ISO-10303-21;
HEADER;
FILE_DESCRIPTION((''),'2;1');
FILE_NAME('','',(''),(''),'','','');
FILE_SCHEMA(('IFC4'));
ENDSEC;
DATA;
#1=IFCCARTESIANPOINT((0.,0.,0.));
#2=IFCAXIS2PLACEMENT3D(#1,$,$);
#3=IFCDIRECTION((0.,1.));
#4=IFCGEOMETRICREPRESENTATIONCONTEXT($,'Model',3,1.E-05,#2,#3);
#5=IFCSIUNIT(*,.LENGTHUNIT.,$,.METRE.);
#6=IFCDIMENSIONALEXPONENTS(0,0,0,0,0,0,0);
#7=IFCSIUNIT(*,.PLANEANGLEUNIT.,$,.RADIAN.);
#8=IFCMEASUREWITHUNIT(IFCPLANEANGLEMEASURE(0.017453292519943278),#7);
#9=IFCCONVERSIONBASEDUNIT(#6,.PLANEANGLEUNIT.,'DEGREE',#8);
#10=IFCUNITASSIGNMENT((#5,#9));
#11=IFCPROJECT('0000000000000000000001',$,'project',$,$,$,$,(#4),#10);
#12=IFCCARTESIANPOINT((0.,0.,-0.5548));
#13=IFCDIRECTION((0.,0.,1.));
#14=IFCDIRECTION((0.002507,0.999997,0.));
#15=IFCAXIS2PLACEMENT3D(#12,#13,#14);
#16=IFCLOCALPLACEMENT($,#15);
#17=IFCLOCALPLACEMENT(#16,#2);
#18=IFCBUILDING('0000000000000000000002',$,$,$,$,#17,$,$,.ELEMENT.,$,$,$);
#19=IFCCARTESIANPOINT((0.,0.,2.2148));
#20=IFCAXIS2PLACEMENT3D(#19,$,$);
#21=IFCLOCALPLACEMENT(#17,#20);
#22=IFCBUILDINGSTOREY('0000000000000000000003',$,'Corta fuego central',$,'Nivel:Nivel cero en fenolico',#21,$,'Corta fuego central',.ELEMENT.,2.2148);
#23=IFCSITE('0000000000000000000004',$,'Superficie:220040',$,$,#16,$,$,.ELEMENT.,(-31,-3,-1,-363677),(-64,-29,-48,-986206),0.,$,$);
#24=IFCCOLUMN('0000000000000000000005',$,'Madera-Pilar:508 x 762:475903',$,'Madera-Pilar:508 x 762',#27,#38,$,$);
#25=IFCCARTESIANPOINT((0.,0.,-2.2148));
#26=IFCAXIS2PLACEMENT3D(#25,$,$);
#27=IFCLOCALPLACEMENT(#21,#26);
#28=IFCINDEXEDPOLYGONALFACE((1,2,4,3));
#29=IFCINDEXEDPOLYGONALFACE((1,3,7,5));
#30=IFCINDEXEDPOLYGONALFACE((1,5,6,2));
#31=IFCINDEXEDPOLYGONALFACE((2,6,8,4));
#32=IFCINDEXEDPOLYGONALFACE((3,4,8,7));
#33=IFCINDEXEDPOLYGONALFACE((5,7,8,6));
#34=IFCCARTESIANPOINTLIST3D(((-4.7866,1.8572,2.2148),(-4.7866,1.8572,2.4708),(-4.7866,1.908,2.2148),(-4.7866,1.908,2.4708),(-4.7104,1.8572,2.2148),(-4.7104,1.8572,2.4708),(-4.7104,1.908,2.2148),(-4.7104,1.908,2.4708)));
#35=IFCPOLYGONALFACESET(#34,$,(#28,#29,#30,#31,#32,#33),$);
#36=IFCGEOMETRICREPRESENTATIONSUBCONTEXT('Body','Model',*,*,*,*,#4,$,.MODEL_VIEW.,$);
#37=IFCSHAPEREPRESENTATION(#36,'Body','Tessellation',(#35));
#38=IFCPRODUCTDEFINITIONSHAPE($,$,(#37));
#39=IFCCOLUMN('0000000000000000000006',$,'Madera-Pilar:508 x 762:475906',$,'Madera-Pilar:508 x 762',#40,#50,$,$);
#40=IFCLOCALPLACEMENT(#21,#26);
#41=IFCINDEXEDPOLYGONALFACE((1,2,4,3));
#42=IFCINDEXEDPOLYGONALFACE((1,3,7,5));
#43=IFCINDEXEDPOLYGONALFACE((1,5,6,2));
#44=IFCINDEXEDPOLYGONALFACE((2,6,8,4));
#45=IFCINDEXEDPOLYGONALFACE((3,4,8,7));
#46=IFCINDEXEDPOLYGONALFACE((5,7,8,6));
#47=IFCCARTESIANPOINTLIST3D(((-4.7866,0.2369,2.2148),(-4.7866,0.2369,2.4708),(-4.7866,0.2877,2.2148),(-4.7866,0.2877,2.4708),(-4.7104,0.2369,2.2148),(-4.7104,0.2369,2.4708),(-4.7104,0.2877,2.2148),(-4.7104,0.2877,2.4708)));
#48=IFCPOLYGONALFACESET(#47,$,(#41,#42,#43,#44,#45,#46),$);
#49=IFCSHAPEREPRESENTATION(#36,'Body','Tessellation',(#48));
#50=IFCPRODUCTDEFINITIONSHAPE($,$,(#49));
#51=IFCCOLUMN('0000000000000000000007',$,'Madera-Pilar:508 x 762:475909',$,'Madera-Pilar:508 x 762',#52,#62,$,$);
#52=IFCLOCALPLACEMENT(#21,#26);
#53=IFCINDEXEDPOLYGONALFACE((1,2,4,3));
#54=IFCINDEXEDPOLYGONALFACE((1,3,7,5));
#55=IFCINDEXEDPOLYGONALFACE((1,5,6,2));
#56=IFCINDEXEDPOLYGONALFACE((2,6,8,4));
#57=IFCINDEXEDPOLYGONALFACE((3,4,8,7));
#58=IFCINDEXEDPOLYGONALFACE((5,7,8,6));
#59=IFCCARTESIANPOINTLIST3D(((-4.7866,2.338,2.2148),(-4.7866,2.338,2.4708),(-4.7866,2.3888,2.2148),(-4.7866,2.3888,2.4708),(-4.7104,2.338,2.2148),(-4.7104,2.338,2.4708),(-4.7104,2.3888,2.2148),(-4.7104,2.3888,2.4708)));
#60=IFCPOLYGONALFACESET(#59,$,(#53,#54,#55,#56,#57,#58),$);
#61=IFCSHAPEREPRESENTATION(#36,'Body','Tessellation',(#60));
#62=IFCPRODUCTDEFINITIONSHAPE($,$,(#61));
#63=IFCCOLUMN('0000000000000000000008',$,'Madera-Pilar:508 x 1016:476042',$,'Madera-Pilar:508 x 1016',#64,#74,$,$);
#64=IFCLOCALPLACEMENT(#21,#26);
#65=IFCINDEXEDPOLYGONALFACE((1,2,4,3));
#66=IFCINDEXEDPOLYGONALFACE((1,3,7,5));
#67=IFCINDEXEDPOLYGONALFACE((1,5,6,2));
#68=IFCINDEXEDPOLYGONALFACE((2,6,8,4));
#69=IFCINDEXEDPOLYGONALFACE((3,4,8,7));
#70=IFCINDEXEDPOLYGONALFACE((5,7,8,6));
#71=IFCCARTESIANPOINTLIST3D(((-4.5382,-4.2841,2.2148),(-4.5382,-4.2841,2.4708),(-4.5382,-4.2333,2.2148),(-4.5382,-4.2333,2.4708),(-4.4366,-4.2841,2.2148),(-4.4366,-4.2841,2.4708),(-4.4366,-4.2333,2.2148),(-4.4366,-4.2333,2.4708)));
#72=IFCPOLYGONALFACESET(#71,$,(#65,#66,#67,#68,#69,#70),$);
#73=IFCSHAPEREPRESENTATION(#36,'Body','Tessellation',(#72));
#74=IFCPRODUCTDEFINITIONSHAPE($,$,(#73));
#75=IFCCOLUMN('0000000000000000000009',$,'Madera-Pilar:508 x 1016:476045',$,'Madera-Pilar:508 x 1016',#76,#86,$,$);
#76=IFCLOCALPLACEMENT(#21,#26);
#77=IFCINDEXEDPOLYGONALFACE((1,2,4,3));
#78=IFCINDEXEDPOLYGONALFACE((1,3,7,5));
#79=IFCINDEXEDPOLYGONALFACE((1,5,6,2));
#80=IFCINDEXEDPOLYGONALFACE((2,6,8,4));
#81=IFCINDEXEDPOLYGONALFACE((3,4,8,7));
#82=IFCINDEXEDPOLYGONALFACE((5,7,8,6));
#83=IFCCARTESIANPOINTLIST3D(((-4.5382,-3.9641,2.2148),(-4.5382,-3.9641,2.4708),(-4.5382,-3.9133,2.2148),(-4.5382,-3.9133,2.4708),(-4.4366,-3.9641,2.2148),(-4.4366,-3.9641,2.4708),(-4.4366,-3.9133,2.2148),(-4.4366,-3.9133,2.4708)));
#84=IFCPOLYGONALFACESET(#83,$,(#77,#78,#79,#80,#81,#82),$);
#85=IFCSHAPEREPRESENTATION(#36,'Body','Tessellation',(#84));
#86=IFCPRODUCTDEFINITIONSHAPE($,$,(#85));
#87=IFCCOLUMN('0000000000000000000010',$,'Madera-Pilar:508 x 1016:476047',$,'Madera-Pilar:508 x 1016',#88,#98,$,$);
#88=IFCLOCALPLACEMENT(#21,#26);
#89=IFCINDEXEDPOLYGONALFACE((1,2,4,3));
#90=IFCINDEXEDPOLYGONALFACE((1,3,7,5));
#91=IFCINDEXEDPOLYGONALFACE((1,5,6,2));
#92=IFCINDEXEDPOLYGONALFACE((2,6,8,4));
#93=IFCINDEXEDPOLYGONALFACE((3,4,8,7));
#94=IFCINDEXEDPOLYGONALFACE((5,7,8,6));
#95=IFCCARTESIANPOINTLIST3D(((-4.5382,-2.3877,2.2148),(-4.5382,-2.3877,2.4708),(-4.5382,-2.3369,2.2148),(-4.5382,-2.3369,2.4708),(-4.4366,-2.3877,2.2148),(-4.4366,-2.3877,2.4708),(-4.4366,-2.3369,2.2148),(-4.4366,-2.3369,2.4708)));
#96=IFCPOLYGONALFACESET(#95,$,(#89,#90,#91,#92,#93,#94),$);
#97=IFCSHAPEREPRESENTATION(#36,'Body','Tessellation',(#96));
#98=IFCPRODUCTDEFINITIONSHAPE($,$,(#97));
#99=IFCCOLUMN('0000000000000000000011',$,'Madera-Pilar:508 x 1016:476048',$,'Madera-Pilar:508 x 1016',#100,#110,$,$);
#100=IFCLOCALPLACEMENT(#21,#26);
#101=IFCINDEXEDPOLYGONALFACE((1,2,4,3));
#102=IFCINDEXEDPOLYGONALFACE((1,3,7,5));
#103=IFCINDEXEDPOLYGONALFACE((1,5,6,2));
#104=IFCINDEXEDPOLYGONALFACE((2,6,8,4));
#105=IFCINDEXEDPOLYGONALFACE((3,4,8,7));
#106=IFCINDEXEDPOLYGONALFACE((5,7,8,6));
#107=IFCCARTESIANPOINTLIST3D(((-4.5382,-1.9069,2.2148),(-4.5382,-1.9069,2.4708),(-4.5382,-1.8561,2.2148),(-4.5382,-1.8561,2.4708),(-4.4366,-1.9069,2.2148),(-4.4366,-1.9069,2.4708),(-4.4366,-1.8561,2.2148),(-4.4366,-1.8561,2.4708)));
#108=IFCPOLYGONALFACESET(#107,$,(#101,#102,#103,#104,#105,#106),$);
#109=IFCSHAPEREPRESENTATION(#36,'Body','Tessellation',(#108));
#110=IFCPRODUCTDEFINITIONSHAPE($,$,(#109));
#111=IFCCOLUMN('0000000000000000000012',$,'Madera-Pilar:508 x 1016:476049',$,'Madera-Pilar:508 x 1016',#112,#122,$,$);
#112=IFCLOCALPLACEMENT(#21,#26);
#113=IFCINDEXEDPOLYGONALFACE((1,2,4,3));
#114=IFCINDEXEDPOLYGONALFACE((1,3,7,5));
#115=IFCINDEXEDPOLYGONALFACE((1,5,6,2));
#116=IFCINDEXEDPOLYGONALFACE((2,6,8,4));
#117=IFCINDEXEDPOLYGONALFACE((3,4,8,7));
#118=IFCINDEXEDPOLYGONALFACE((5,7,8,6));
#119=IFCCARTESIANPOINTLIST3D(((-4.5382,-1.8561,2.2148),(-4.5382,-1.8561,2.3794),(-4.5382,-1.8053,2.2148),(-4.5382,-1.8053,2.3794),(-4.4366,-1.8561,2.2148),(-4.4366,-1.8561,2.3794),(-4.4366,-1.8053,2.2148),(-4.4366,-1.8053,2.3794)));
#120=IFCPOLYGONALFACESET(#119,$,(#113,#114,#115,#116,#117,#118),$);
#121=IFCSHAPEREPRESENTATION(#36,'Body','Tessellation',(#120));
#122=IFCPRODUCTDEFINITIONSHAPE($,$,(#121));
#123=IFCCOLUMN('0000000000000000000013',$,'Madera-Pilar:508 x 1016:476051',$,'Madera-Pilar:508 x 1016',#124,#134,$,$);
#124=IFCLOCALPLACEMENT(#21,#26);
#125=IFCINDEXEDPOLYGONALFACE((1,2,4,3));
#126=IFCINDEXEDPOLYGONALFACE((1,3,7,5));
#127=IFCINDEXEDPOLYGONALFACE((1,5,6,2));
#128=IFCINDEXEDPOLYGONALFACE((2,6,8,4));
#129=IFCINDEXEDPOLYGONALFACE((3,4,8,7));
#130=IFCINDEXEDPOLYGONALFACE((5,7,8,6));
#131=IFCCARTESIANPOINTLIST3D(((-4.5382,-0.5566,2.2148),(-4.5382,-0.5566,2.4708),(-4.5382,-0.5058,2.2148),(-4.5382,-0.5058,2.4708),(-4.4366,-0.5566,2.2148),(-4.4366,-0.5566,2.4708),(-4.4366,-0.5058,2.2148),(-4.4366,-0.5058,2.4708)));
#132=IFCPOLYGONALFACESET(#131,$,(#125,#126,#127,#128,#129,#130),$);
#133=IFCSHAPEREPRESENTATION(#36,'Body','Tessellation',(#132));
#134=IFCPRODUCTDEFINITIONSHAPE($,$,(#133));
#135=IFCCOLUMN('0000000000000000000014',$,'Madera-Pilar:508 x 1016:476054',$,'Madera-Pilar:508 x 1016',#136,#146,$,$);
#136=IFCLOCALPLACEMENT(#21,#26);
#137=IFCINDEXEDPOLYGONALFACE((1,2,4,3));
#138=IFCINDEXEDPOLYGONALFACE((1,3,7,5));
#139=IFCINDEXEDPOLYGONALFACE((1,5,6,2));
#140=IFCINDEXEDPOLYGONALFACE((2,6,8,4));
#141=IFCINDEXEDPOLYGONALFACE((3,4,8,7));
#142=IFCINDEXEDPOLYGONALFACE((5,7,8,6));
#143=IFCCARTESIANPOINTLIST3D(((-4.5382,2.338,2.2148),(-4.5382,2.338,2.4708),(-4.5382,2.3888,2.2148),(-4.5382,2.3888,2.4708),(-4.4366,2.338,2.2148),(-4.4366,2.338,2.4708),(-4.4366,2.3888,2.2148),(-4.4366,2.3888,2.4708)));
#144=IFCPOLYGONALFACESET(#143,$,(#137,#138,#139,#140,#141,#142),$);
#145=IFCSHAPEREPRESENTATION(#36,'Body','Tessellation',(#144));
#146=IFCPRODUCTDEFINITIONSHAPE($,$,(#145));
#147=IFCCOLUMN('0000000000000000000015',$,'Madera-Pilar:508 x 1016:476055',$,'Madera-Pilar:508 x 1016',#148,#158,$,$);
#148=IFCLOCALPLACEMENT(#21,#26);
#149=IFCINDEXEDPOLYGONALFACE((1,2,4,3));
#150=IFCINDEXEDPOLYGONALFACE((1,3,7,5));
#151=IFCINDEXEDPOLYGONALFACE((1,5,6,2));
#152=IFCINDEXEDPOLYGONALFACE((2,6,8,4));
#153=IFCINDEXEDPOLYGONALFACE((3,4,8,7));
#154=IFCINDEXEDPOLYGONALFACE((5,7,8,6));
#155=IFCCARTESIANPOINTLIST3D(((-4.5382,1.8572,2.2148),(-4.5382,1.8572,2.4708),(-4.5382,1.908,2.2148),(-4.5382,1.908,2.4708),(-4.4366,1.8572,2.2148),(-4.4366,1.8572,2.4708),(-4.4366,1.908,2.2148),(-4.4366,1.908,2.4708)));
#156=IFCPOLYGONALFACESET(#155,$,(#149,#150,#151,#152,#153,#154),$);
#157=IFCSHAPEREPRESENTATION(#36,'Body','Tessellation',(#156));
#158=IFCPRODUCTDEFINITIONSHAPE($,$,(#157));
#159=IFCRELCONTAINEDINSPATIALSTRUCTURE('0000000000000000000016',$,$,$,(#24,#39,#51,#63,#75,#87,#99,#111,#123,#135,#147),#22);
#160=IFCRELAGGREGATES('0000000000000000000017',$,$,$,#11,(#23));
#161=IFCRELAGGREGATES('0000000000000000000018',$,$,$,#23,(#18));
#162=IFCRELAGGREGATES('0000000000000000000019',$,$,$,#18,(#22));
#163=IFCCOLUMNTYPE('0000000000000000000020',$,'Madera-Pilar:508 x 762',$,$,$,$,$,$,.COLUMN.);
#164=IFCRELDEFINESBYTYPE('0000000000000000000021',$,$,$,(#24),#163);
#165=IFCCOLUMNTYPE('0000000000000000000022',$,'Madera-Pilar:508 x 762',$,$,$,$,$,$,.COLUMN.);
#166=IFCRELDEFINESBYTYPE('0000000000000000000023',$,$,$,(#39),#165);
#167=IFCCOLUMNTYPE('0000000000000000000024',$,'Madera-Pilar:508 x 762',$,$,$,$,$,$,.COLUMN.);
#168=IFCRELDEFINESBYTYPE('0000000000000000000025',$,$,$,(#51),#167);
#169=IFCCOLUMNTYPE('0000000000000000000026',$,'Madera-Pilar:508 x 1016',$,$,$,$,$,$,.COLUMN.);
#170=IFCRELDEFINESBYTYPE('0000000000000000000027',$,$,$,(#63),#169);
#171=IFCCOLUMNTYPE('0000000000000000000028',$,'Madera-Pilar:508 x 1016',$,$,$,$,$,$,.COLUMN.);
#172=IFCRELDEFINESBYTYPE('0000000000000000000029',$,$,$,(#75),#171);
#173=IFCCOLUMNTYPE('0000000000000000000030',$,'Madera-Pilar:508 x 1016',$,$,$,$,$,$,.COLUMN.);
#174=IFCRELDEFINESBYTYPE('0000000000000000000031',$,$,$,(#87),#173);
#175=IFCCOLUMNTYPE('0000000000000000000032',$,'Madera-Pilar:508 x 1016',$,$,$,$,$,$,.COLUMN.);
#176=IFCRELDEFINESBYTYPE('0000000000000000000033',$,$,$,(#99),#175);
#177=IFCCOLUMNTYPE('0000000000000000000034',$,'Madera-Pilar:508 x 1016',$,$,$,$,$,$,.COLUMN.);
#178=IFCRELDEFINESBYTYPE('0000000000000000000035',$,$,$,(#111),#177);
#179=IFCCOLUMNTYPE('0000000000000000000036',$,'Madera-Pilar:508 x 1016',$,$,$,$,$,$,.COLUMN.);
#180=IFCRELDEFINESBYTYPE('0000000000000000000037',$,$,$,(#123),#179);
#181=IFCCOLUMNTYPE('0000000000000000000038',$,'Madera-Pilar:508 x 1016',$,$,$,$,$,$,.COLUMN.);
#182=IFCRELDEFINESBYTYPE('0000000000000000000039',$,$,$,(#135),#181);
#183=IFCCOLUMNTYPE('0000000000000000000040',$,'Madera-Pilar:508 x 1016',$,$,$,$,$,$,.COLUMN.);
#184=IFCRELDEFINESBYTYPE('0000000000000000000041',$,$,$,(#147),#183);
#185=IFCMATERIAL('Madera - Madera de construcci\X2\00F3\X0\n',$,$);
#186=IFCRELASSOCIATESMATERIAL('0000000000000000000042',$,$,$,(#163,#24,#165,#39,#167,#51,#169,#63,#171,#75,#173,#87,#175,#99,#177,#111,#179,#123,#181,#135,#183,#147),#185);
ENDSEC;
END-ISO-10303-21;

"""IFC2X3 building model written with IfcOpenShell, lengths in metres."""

from ifc_helpers import new_model, entity, si_unit, converted_unit, direction, frame, frame_2d, origin, origin_2d_with_axis, place, context, subcontext, project, spatial, rectangle, extrude, source, transform, mapped, material, type_object, type_shapes, element, save


model = new_model("IFC2X3")

# Units and contexts
model_context = context("Model", 3, precision=1e-05, world=origin(), true_north=direction((0.0, 1.0)))
body_context = subcontext(model_context, "Body", "Model", "MODEL_VIEW")
ifc_project = project(units=[si_unit("LENGTHUNIT", "METRE"), converted_unit("PLANEANGLEUNIT", "DEGREE", entity("IfcPlaneAngleMeasure", 0.017453292519943278), si_unit("PLANEANGLEUNIT", "RADIAN"), dimensions=[0, 0, 0, 0, 0, 0, 0])], contexts=[model_context])

# Site, building, storey
site_placement = place(None, frame((0.0, 0.0, -0.5548), z_axis=(0.0, 0.0, 1.0), x_axis=(0.002507, 0.999997, 0.0)))
site = spatial("IfcSite", under=ifc_project, at=site_placement, Name="Superficie:220040", CompositionType="ELEMENT", RefLatitude=(-31, -3, -1, -363677), RefLongitude=(-64, -29, -48, -986206), RefElevation=0.0)
building_placement = place(site_placement, origin())
building = spatial("IfcBuilding", under=site, at=building_placement, CompositionType="ELEMENT")
storey_placement = place(building_placement, frame((0.0, 0.0, 2.2148)))
storey = spatial("IfcBuildingStorey", under=building, at=storey_placement, Name="Corta fuego central", ObjectType="Nivel:Nivel cero en fenolico", LongName="Corta fuego central", CompositionType="ELEMENT", Elevation=2.2148)

# Columns
ifc_material = material(Name="Madera - Madera de construcción")
column_type_1 = type_object("IfcColumnType", Name="Madera-Pilar:508 x 762", PredefinedType="COLUMN", material=ifc_material)
shared_shape_1 = source(origin(), body_context, "Body", "SweptSolid", [
    extrude(rectangle(XDim=0.0762, YDim=0.0508, at=origin_2d_with_axis()), frame((-4.7485, 1.8826, 2.2148), z_axis=(0.0, 0.0, 1.0), x_axis=(-1.0, 0.0, 0.0)), (0.0, 0.0, 1.0), 0.256),
])
type_shapes(column_type_1, [shared_shape_1])
column_1_placement = place(storey_placement, frame((0.0, 0.0, -2.2148)))
element("IfcColumn", 1, at=column_1_placement, inside=storey, type_object=column_type_1, material=ifc_material, Name="Madera-Pilar:508 x 762:475903", ObjectType="Madera-Pilar:508 x 762", context=body_context, shape_type="MappedRepresentation", body=[
    mapped(shared_shape_1, transform((0.0, 0.0, 0.0), scale=1.0)),
])
column_type_2 = type_object("IfcColumnType", Name="Madera-Pilar:508 x 762", PredefinedType="COLUMN", material=ifc_material)
shared_shape_2 = source(origin(), body_context, "Body", "SweptSolid", [
    extrude(rectangle(XDim=0.0762, YDim=0.0508, at=frame_2d((0.0, 0.0), x_axis=(1.0, 0.0))), frame((-4.7485, 0.2623, 2.2148), z_axis=(0.0, 0.0, 1.0), x_axis=(-1.0, 0.0, 0.0)), (0.0, 0.0, 1.0), 0.256),
])
type_shapes(column_type_2, [shared_shape_2])
column_2_placement = place(storey_placement, frame((0.0, 0.0, -2.2148)))
element("IfcColumn", 2, at=column_2_placement, inside=storey, type_object=column_type_2, material=ifc_material, Name="Madera-Pilar:508 x 762:475906", ObjectType="Madera-Pilar:508 x 762", context=body_context, shape_type="MappedRepresentation", body=[
    mapped(shared_shape_2, transform((0.0, 0.0, 0.0), scale=1.0)),
])
column_type_3 = type_object("IfcColumnType", Name="Madera-Pilar:508 x 762", PredefinedType="COLUMN", material=ifc_material)
shared_shape_3 = source(origin(), body_context, "Body", "SweptSolid", [
    extrude(rectangle(XDim=0.0762, YDim=0.0508, at=origin_2d_with_axis()), frame((-4.7485, 2.3634, 2.2148), z_axis=(0.0, 0.0, 1.0), x_axis=(-1.0, 0.0, 0.0)), (0.0, 0.0, 1.0), 0.256),
])
type_shapes(column_type_3, [shared_shape_3])
column_3_placement = place(storey_placement, frame((0.0, 0.0, -2.2148)))
element("IfcColumn", 3, at=column_3_placement, inside=storey, type_object=column_type_3, material=ifc_material, Name="Madera-Pilar:508 x 762:475909", ObjectType="Madera-Pilar:508 x 762", context=body_context, shape_type="MappedRepresentation", body=[
    mapped(shared_shape_3, transform((0.0, 0.0, 0.0), scale=1.0)),
])
column_type_4 = type_object("IfcColumnType", Name="Madera-Pilar:508 x 1016", PredefinedType="COLUMN", material=ifc_material)
shared_shape_4 = source(origin(), body_context, "Body", "SweptSolid", [
    extrude(rectangle(XDim=0.1016, YDim=0.0508, at=frame_2d((0.0, 0.0), x_axis=(1.0, 0.0))), frame((-4.4874, -4.2587, 2.2148), z_axis=(0.0, 0.0, 1.0), x_axis=(-1.0, 0.0, 0.0)), (0.0, 0.0, 1.0), 0.256),
])
type_shapes(column_type_4, [shared_shape_4])
column_4_placement = place(storey_placement, frame((0.0, 0.0, -2.2148)))
element("IfcColumn", 4, at=column_4_placement, inside=storey, type_object=column_type_4, material=ifc_material, Name="Madera-Pilar:508 x 1016:476042", ObjectType="Madera-Pilar:508 x 1016", context=body_context, shape_type="MappedRepresentation", body=[
    mapped(shared_shape_4, transform((0.0, 0.0, 0.0), scale=1.0)),
])
column_type_5 = type_object("IfcColumnType", Name="Madera-Pilar:508 x 1016", PredefinedType="COLUMN", material=ifc_material)
shared_shape_5 = source(origin(), body_context, "Body", "SweptSolid", [
    extrude(rectangle(XDim=0.1016, YDim=0.0508, at=frame_2d((0.0, 0.0), x_axis=(1.0, 0.0))), frame((-4.4874, -3.9387, 2.2148), z_axis=(0.0, 0.0, 1.0), x_axis=(-1.0, 0.0, 0.0)), (0.0, 0.0, 1.0), 0.256),
])
type_shapes(column_type_5, [shared_shape_5])
column_5_placement = place(storey_placement, frame((0.0, 0.0, -2.2148)))
element("IfcColumn", 5, at=column_5_placement, inside=storey, type_object=column_type_5, material=ifc_material, Name="Madera-Pilar:508 x 1016:476045", ObjectType="Madera-Pilar:508 x 1016", context=body_context, shape_type="MappedRepresentation", body=[
    mapped(shared_shape_5, transform((0.0, 0.0, 0.0), scale=1.0)),
])
column_type_6 = type_object("IfcColumnType", Name="Madera-Pilar:508 x 1016", PredefinedType="COLUMN", material=ifc_material)
shared_shape_6 = source(origin(), body_context, "Body", "SweptSolid", [
    extrude(rectangle(XDim=0.1016, YDim=0.0508, at=frame_2d((0.0, 0.0), x_axis=(1.0, 0.0))), frame((-4.4874, -2.3623, 2.2148), z_axis=(0.0, 0.0, 1.0), x_axis=(-1.0, 0.0, 0.0)), (0.0, 0.0, 1.0), 0.256),
])
type_shapes(column_type_6, [shared_shape_6])
column_6_placement = place(storey_placement, frame((0.0, 0.0, -2.2148)))
element("IfcColumn", 6, at=column_6_placement, inside=storey, type_object=column_type_6, material=ifc_material, Name="Madera-Pilar:508 x 1016:476047", ObjectType="Madera-Pilar:508 x 1016", context=body_context, shape_type="MappedRepresentation", body=[
    mapped(shared_shape_6, transform((0.0, 0.0, 0.0), scale=1.0)),
])
column_type_7 = type_object("IfcColumnType", Name="Madera-Pilar:508 x 1016", PredefinedType="COLUMN", material=ifc_material)
shared_shape_7 = source(origin(), body_context, "Body", "SweptSolid", [
    extrude(rectangle(XDim=0.1016, YDim=0.0508, at=frame_2d((0.0, 0.0), x_axis=(1.0, 0.0))), frame((-4.4874, -1.8815, 2.2148), z_axis=(0.0, 0.0, 1.0), x_axis=(-1.0, 0.0, 0.0)), (0.0, 0.0, 1.0), 0.256),
])
type_shapes(column_type_7, [shared_shape_7])
column_7_placement = place(storey_placement, frame((0.0, 0.0, -2.2148)))
element("IfcColumn", 7, at=column_7_placement, inside=storey, type_object=column_type_7, material=ifc_material, Name="Madera-Pilar:508 x 1016:476048", ObjectType="Madera-Pilar:508 x 1016", context=body_context, shape_type="MappedRepresentation", body=[
    mapped(shared_shape_7, transform((0.0, 0.0, 0.0), scale=1.0)),
])
column_type_8 = type_object("IfcColumnType", Name="Madera-Pilar:508 x 1016", PredefinedType="COLUMN", material=ifc_material)
shared_shape_8 = source(origin(), body_context, "Body", "SweptSolid", [
    extrude(rectangle(XDim=0.1016, YDim=0.0508, at=frame_2d((0.0, 0.0), x_axis=(1.0, 0.0))), frame((-4.4874, -1.8307, 2.2148), z_axis=(0.0, 0.0, 1.0), x_axis=(-1.0, 0.0, 0.0)), (0.0, 0.0, 1.0), 0.1646),
])
type_shapes(column_type_8, [shared_shape_8])
column_8_placement = place(storey_placement, frame((0.0, 0.0, -2.2148)))
element("IfcColumn", 8, at=column_8_placement, inside=storey, type_object=column_type_8, material=ifc_material, Name="Madera-Pilar:508 x 1016:476049", ObjectType="Madera-Pilar:508 x 1016", context=body_context, shape_type="MappedRepresentation", body=[
    mapped(shared_shape_8, transform((0.0, 0.0, 0.0), scale=1.0)),
])
column_type_9 = type_object("IfcColumnType", Name="Madera-Pilar:508 x 1016", PredefinedType="COLUMN", material=ifc_material)
shared_shape_9 = source(origin(), body_context, "Body", "SweptSolid", [
    extrude(rectangle(XDim=0.1016, YDim=0.0508, at=frame_2d((0.0, 0.0), x_axis=(1.0, 0.0))), frame((-4.4874, -0.5312, 2.2148), z_axis=(0.0, 0.0, 1.0), x_axis=(-1.0, 0.0, 0.0)), (0.0, 0.0, 1.0), 0.256),
])
type_shapes(column_type_9, [shared_shape_9])
column_9_placement = place(storey_placement, frame((0.0, 0.0, -2.2148)))
element("IfcColumn", 9, at=column_9_placement, inside=storey, type_object=column_type_9, material=ifc_material, Name="Madera-Pilar:508 x 1016:476051", ObjectType="Madera-Pilar:508 x 1016", context=body_context, shape_type="MappedRepresentation", body=[
    mapped(shared_shape_9, transform((0.0, 0.0, 0.0), scale=1.0)),
])
column_type_10 = type_object("IfcColumnType", Name="Madera-Pilar:508 x 1016", PredefinedType="COLUMN", material=ifc_material)
shared_shape_10 = source(origin(), body_context, "Body", "SweptSolid", [
    extrude(rectangle(XDim=0.1016, YDim=0.0508, at=frame_2d((0.0, 0.0), x_axis=(1.0, 0.0))), frame((-4.4874, 2.3634, 2.2148), z_axis=(0.0, 0.0, 1.0), x_axis=(-1.0, 0.0, 0.0)), (0.0, 0.0, 1.0), 0.256),
])
type_shapes(column_type_10, [shared_shape_10])
column_10_placement = place(storey_placement, frame((0.0, 0.0, -2.2148)))
element("IfcColumn", 10, at=column_10_placement, inside=storey, type_object=column_type_10, material=ifc_material, Name="Madera-Pilar:508 x 1016:476054", ObjectType="Madera-Pilar:508 x 1016", context=body_context, shape_type="MappedRepresentation", body=[
    mapped(shared_shape_10, transform((0.0, 0.0, 0.0), scale=1.0)),
])
column_type_11 = type_object("IfcColumnType", Name="Madera-Pilar:508 x 1016", PredefinedType="COLUMN", material=ifc_material)
shared_shape_11 = source(origin(), body_context, "Body", "SweptSolid", [
    extrude(rectangle(XDim=0.1016, YDim=0.0508, at=frame_2d((0.0, 0.0), x_axis=(1.0, 0.0))), frame((-4.4874, 1.8826, 2.2148), z_axis=(0.0, 0.0, 1.0), x_axis=(-1.0, 0.0, 0.0)), (0.0, 0.0, 1.0), 0.256),
])
type_shapes(column_type_11, [shared_shape_11])
column_11_placement = place(storey_placement, frame((0.0, 0.0, -2.2148)))
element("IfcColumn", 11, at=column_11_placement, inside=storey, type_object=column_type_11, material=ifc_material, Name="Madera-Pilar:508 x 1016:476055", ObjectType="Madera-Pilar:508 x 1016", context=body_context, shape_type="MappedRepresentation", body=[
    mapped(shared_shape_11, transform((0.0, 0.0, 0.0), scale=1.0)),
])

save(model, "model.ifc")
